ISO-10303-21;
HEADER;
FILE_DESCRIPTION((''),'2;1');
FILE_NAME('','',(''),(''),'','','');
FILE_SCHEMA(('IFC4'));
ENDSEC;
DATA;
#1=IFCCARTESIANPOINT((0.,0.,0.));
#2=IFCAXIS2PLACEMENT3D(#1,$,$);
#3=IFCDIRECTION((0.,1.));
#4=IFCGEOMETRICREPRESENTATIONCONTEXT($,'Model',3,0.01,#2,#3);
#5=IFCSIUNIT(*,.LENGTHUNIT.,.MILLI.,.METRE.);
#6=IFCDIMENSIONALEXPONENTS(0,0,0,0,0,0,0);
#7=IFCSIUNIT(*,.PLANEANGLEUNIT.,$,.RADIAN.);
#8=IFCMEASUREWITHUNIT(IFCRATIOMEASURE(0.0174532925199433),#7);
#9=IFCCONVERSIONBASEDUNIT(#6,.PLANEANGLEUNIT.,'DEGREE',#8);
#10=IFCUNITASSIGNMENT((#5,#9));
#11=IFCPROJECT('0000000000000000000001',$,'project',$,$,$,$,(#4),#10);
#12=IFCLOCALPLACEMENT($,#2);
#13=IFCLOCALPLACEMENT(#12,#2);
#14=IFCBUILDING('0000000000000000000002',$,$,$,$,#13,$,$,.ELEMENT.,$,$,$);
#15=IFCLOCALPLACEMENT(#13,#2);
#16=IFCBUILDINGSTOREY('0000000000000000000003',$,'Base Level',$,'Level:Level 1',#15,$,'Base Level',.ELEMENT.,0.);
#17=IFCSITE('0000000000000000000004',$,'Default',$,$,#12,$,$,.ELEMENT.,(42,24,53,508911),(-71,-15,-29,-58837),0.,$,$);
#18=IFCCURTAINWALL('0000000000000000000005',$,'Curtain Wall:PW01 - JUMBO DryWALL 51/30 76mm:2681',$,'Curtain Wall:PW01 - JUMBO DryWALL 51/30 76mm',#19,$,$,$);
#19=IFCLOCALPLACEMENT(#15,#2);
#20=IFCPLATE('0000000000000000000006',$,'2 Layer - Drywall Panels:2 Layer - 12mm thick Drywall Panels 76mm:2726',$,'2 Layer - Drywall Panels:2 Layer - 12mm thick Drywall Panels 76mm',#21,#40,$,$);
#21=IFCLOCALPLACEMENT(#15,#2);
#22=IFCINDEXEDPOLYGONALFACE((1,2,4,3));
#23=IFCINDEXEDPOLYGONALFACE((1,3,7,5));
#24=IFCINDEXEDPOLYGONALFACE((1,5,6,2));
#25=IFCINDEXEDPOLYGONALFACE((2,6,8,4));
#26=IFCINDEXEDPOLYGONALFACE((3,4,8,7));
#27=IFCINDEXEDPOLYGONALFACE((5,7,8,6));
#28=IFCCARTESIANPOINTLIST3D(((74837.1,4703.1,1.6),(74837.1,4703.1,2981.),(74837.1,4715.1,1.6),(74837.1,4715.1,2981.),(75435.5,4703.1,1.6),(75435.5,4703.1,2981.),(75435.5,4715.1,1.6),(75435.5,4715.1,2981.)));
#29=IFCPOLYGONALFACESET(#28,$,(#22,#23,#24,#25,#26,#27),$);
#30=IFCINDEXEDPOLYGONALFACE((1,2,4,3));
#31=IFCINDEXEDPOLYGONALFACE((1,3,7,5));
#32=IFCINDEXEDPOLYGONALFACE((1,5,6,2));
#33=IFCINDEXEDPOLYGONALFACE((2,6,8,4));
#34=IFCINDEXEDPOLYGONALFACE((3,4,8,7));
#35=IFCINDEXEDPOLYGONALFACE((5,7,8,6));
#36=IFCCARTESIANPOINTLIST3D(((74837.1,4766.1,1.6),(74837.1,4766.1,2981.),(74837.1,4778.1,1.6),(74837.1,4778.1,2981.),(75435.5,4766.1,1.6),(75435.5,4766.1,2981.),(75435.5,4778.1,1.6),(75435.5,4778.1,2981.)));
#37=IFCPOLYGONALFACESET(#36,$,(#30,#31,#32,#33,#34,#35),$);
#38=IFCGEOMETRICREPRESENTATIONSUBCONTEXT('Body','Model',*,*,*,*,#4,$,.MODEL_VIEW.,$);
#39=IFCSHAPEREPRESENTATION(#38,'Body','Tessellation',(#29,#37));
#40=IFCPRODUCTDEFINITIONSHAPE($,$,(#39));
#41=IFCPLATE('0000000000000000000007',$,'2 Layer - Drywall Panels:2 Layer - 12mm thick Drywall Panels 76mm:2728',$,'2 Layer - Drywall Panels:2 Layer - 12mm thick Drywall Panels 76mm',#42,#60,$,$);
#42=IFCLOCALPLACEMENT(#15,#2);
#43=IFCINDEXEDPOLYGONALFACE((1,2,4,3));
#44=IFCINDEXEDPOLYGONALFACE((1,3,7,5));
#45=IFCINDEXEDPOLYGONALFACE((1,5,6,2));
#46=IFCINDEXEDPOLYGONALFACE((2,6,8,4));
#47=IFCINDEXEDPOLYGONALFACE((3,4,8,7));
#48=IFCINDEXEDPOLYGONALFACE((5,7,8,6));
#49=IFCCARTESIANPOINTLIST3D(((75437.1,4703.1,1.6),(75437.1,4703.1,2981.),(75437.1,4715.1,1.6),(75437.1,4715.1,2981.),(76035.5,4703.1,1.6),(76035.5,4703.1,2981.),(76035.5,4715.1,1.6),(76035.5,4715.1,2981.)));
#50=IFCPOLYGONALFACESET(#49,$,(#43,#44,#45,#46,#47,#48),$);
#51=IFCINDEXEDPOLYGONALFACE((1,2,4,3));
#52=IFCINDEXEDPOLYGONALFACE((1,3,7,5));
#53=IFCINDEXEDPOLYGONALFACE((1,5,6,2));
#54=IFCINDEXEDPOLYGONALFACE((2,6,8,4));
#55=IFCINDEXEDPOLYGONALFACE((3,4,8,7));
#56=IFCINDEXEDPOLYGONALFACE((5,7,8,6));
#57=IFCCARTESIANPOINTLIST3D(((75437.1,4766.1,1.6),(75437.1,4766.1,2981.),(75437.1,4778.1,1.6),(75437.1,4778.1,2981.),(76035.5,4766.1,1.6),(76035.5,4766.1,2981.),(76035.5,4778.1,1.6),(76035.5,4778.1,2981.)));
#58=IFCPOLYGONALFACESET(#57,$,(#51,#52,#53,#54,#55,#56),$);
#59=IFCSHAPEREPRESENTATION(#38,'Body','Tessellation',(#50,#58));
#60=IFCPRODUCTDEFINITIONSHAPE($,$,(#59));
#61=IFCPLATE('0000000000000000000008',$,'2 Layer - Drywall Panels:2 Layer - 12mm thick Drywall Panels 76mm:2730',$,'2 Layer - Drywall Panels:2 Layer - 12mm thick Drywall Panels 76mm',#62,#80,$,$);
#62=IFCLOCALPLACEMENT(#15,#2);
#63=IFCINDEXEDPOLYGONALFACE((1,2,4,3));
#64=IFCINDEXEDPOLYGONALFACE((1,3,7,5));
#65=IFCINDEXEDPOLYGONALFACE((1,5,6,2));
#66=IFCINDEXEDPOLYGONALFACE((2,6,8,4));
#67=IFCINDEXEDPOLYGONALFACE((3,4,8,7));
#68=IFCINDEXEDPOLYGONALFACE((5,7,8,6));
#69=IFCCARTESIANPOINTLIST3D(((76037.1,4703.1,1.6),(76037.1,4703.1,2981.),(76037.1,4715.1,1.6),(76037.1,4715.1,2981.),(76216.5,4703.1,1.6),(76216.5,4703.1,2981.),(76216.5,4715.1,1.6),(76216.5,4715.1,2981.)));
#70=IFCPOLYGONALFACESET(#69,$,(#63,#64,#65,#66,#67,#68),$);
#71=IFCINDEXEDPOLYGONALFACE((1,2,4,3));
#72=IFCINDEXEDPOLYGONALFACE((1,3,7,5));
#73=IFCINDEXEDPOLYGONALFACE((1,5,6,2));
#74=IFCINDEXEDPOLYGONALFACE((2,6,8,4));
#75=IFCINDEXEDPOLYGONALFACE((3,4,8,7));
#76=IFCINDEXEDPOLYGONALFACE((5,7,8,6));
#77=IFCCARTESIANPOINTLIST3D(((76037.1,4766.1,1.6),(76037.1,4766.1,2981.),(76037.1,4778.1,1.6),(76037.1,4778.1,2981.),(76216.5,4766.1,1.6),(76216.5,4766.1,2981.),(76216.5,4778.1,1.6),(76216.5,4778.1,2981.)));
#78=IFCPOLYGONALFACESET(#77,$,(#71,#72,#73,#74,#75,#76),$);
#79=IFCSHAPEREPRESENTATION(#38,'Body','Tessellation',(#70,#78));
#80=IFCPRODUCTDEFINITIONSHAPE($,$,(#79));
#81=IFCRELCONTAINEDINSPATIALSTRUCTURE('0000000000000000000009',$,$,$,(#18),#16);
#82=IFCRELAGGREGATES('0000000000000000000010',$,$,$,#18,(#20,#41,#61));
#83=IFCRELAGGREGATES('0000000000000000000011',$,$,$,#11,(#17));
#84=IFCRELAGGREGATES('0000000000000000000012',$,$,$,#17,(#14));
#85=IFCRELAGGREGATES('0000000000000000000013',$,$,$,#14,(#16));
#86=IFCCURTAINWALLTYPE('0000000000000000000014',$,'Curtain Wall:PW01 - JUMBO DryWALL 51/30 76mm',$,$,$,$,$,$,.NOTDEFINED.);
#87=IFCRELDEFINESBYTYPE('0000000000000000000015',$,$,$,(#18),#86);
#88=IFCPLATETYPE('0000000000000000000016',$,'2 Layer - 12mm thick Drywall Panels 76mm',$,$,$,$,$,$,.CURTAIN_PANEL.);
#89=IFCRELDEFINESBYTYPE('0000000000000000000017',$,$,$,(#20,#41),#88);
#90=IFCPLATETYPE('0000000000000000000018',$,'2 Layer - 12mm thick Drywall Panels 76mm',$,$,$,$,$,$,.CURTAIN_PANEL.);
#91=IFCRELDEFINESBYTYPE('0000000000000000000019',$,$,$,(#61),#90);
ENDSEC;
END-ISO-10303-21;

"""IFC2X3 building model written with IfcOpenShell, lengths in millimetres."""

from ifc_helpers import new_model, entity, si_unit, converted_unit, direction, frame, frame_2d, origin, origin_2d_with_axis, place, context, subcontext, project, spatial, rectangle, extrude, source, transform, mapped, type_object, type_shapes, element, aggregate, save


model = new_model("IFC2X3")

# Units and contexts
model_context = context("Model", 3, precision=0.01, world=origin(), true_north=direction((0.0, 1.0)))
body_context = subcontext(model_context, "Body", "Model", "MODEL_VIEW")
ifc_project = project(units=[si_unit("LENGTHUNIT", "METRE", prefix="MILLI"), converted_unit("PLANEANGLEUNIT", "DEGREE", entity("IfcRatioMeasure", 0.0174532925199433), si_unit("PLANEANGLEUNIT", "RADIAN"), dimensions=[0, 0, 0, 0, 0, 0, 0])], contexts=[model_context])

# Site, building, storey
site_placement = place(None, origin())
site = spatial("IfcSite", under=ifc_project, at=site_placement, Name="Default", CompositionType="ELEMENT", RefLatitude=(42, 24, 53, 508911), RefLongitude=(-71, -15, -29, -58837), RefElevation=0.0)
building_placement = place(site_placement, origin())
building = spatial("IfcBuilding", under=site, at=building_placement, CompositionType="ELEMENT")
storey_placement = place(building_placement, origin())
storey = spatial("IfcBuildingStorey", under=building, at=storey_placement, Name="Base Level", ObjectType="Level:Level 1", LongName="Base Level", CompositionType="ELEMENT", Elevation=0.0)

# Curtain wall, plates
curtain_wall_type = type_object("IfcCurtainWallType", Name="Curtain Wall:PW01 - JUMBO DryWALL 51/30 76mm", PredefinedType="NOTDEFINED")
curtain_wall_placement = place(building_placement, origin())
curtain_wall = element("IfcCurtainWall", 1, at=curtain_wall_placement, inside=storey, type_object=curtain_wall_type, Name="Curtain Wall:PW01 - JUMBO DryWALL 51/30 76mm:2681", ObjectType="Curtain Wall:PW01 - JUMBO DryWALL 51/30 76mm")
plate_type_1 = type_object("IfcPlateType", Name="2 Layer - 12mm thick Drywall Panels 76mm", PredefinedType="CURTAIN_PANEL")
shared_shape_1 = source(origin(), body_context, "Body", "SweptSolid", [
    extrude(rectangle(XDim=598.4, YDim=12.0, at=origin_2d_with_axis()), frame((0.0, -31.5, 0.0), z_axis=(0.0, 0.0, 1.0), x_axis=(-1.0, 0.0, 0.0)), (0.0, 0.0, 1.0), 2979.4),
    extrude(rectangle(XDim=12.0, YDim=598.4, at=frame_2d((0.0, 0.0), x_axis=(1.0, 0.0))), frame((0.0, 31.5, 0.0), z_axis=(0.0, 0.0, 1.0), x_axis=(0.0, 1.0, 0.0)), (0.0, 0.0, 1.0), 2979.4),
])
type_shapes(plate_type_1, [shared_shape_1])
plate_1_placement = place(curtain_wall_placement, frame((75136.3, 4740.6, 1.6)))
plate_1 = element("IfcPlate", 2, at=plate_1_placement, type_object=plate_type_1, Name="2 Layer - Drywall Panels:2 Layer - 12mm thick Drywall Panels 76mm:2726", ObjectType="2 Layer - Drywall Panels:2 Layer - 12mm thick Drywall Panels 76mm", context=body_context, shape_type="MappedRepresentation", body=[
    mapped(shared_shape_1, transform((0.0, 0.0, 0.0), scale=1.0)),
])
plate_2_placement = place(curtain_wall_placement, frame((75736.3, 4740.6, 1.6)))
plate_2 = element("IfcPlate", 3, at=plate_2_placement, type_object=plate_type_1, Name="2 Layer - Drywall Panels:2 Layer - 12mm thick Drywall Panels 76mm:2728", ObjectType="2 Layer - Drywall Panels:2 Layer - 12mm thick Drywall Panels 76mm", context=body_context, shape_type="MappedRepresentation", body=[
    mapped(shared_shape_1, transform((0.0, 0.0, 0.0), scale=1.0)),
])
plate_type_2 = type_object("IfcPlateType", Name="2 Layer - 12mm thick Drywall Panels 76mm", PredefinedType="CURTAIN_PANEL")
shared_shape_2 = source(origin(), body_context, "Body", "SweptSolid", [
    extrude(rectangle(XDim=179.4, YDim=12.0, at=origin_2d_with_axis()), frame((0.0, -31.5, 0.0), z_axis=(0.0, 0.0, 1.0), x_axis=(-1.0, 0.0, 0.0)), (0.0, 0.0, 1.0), 2979.4),
    extrude(rectangle(XDim=12.0, YDim=179.4, at=frame_2d((0.0, 0.0), x_axis=(1.0, 0.0))), frame((0.0, 31.5, 0.0), z_axis=(0.0, 0.0, 1.0), x_axis=(0.0, 1.0, 0.0)), (0.0, 0.0, 1.0), 2979.4),
])
type_shapes(plate_type_2, [shared_shape_2])
plate_3_placement = place(curtain_wall_placement, frame((76126.8, 4740.6, 1.6)))
plate_3 = element("IfcPlate", 4, at=plate_3_placement, type_object=plate_type_2, Name="2 Layer - Drywall Panels:2 Layer - 12mm thick Drywall Panels 76mm:2730", ObjectType="2 Layer - Drywall Panels:2 Layer - 12mm thick Drywall Panels 76mm", context=body_context, shape_type="MappedRepresentation", body=[
    mapped(shared_shape_2, transform((0.0, 0.0, 0.0), scale=1.0)),
])
aggregate(curtain_wall, [plate_1, plate_2, plate_3])

save(model, "model.ifc")
